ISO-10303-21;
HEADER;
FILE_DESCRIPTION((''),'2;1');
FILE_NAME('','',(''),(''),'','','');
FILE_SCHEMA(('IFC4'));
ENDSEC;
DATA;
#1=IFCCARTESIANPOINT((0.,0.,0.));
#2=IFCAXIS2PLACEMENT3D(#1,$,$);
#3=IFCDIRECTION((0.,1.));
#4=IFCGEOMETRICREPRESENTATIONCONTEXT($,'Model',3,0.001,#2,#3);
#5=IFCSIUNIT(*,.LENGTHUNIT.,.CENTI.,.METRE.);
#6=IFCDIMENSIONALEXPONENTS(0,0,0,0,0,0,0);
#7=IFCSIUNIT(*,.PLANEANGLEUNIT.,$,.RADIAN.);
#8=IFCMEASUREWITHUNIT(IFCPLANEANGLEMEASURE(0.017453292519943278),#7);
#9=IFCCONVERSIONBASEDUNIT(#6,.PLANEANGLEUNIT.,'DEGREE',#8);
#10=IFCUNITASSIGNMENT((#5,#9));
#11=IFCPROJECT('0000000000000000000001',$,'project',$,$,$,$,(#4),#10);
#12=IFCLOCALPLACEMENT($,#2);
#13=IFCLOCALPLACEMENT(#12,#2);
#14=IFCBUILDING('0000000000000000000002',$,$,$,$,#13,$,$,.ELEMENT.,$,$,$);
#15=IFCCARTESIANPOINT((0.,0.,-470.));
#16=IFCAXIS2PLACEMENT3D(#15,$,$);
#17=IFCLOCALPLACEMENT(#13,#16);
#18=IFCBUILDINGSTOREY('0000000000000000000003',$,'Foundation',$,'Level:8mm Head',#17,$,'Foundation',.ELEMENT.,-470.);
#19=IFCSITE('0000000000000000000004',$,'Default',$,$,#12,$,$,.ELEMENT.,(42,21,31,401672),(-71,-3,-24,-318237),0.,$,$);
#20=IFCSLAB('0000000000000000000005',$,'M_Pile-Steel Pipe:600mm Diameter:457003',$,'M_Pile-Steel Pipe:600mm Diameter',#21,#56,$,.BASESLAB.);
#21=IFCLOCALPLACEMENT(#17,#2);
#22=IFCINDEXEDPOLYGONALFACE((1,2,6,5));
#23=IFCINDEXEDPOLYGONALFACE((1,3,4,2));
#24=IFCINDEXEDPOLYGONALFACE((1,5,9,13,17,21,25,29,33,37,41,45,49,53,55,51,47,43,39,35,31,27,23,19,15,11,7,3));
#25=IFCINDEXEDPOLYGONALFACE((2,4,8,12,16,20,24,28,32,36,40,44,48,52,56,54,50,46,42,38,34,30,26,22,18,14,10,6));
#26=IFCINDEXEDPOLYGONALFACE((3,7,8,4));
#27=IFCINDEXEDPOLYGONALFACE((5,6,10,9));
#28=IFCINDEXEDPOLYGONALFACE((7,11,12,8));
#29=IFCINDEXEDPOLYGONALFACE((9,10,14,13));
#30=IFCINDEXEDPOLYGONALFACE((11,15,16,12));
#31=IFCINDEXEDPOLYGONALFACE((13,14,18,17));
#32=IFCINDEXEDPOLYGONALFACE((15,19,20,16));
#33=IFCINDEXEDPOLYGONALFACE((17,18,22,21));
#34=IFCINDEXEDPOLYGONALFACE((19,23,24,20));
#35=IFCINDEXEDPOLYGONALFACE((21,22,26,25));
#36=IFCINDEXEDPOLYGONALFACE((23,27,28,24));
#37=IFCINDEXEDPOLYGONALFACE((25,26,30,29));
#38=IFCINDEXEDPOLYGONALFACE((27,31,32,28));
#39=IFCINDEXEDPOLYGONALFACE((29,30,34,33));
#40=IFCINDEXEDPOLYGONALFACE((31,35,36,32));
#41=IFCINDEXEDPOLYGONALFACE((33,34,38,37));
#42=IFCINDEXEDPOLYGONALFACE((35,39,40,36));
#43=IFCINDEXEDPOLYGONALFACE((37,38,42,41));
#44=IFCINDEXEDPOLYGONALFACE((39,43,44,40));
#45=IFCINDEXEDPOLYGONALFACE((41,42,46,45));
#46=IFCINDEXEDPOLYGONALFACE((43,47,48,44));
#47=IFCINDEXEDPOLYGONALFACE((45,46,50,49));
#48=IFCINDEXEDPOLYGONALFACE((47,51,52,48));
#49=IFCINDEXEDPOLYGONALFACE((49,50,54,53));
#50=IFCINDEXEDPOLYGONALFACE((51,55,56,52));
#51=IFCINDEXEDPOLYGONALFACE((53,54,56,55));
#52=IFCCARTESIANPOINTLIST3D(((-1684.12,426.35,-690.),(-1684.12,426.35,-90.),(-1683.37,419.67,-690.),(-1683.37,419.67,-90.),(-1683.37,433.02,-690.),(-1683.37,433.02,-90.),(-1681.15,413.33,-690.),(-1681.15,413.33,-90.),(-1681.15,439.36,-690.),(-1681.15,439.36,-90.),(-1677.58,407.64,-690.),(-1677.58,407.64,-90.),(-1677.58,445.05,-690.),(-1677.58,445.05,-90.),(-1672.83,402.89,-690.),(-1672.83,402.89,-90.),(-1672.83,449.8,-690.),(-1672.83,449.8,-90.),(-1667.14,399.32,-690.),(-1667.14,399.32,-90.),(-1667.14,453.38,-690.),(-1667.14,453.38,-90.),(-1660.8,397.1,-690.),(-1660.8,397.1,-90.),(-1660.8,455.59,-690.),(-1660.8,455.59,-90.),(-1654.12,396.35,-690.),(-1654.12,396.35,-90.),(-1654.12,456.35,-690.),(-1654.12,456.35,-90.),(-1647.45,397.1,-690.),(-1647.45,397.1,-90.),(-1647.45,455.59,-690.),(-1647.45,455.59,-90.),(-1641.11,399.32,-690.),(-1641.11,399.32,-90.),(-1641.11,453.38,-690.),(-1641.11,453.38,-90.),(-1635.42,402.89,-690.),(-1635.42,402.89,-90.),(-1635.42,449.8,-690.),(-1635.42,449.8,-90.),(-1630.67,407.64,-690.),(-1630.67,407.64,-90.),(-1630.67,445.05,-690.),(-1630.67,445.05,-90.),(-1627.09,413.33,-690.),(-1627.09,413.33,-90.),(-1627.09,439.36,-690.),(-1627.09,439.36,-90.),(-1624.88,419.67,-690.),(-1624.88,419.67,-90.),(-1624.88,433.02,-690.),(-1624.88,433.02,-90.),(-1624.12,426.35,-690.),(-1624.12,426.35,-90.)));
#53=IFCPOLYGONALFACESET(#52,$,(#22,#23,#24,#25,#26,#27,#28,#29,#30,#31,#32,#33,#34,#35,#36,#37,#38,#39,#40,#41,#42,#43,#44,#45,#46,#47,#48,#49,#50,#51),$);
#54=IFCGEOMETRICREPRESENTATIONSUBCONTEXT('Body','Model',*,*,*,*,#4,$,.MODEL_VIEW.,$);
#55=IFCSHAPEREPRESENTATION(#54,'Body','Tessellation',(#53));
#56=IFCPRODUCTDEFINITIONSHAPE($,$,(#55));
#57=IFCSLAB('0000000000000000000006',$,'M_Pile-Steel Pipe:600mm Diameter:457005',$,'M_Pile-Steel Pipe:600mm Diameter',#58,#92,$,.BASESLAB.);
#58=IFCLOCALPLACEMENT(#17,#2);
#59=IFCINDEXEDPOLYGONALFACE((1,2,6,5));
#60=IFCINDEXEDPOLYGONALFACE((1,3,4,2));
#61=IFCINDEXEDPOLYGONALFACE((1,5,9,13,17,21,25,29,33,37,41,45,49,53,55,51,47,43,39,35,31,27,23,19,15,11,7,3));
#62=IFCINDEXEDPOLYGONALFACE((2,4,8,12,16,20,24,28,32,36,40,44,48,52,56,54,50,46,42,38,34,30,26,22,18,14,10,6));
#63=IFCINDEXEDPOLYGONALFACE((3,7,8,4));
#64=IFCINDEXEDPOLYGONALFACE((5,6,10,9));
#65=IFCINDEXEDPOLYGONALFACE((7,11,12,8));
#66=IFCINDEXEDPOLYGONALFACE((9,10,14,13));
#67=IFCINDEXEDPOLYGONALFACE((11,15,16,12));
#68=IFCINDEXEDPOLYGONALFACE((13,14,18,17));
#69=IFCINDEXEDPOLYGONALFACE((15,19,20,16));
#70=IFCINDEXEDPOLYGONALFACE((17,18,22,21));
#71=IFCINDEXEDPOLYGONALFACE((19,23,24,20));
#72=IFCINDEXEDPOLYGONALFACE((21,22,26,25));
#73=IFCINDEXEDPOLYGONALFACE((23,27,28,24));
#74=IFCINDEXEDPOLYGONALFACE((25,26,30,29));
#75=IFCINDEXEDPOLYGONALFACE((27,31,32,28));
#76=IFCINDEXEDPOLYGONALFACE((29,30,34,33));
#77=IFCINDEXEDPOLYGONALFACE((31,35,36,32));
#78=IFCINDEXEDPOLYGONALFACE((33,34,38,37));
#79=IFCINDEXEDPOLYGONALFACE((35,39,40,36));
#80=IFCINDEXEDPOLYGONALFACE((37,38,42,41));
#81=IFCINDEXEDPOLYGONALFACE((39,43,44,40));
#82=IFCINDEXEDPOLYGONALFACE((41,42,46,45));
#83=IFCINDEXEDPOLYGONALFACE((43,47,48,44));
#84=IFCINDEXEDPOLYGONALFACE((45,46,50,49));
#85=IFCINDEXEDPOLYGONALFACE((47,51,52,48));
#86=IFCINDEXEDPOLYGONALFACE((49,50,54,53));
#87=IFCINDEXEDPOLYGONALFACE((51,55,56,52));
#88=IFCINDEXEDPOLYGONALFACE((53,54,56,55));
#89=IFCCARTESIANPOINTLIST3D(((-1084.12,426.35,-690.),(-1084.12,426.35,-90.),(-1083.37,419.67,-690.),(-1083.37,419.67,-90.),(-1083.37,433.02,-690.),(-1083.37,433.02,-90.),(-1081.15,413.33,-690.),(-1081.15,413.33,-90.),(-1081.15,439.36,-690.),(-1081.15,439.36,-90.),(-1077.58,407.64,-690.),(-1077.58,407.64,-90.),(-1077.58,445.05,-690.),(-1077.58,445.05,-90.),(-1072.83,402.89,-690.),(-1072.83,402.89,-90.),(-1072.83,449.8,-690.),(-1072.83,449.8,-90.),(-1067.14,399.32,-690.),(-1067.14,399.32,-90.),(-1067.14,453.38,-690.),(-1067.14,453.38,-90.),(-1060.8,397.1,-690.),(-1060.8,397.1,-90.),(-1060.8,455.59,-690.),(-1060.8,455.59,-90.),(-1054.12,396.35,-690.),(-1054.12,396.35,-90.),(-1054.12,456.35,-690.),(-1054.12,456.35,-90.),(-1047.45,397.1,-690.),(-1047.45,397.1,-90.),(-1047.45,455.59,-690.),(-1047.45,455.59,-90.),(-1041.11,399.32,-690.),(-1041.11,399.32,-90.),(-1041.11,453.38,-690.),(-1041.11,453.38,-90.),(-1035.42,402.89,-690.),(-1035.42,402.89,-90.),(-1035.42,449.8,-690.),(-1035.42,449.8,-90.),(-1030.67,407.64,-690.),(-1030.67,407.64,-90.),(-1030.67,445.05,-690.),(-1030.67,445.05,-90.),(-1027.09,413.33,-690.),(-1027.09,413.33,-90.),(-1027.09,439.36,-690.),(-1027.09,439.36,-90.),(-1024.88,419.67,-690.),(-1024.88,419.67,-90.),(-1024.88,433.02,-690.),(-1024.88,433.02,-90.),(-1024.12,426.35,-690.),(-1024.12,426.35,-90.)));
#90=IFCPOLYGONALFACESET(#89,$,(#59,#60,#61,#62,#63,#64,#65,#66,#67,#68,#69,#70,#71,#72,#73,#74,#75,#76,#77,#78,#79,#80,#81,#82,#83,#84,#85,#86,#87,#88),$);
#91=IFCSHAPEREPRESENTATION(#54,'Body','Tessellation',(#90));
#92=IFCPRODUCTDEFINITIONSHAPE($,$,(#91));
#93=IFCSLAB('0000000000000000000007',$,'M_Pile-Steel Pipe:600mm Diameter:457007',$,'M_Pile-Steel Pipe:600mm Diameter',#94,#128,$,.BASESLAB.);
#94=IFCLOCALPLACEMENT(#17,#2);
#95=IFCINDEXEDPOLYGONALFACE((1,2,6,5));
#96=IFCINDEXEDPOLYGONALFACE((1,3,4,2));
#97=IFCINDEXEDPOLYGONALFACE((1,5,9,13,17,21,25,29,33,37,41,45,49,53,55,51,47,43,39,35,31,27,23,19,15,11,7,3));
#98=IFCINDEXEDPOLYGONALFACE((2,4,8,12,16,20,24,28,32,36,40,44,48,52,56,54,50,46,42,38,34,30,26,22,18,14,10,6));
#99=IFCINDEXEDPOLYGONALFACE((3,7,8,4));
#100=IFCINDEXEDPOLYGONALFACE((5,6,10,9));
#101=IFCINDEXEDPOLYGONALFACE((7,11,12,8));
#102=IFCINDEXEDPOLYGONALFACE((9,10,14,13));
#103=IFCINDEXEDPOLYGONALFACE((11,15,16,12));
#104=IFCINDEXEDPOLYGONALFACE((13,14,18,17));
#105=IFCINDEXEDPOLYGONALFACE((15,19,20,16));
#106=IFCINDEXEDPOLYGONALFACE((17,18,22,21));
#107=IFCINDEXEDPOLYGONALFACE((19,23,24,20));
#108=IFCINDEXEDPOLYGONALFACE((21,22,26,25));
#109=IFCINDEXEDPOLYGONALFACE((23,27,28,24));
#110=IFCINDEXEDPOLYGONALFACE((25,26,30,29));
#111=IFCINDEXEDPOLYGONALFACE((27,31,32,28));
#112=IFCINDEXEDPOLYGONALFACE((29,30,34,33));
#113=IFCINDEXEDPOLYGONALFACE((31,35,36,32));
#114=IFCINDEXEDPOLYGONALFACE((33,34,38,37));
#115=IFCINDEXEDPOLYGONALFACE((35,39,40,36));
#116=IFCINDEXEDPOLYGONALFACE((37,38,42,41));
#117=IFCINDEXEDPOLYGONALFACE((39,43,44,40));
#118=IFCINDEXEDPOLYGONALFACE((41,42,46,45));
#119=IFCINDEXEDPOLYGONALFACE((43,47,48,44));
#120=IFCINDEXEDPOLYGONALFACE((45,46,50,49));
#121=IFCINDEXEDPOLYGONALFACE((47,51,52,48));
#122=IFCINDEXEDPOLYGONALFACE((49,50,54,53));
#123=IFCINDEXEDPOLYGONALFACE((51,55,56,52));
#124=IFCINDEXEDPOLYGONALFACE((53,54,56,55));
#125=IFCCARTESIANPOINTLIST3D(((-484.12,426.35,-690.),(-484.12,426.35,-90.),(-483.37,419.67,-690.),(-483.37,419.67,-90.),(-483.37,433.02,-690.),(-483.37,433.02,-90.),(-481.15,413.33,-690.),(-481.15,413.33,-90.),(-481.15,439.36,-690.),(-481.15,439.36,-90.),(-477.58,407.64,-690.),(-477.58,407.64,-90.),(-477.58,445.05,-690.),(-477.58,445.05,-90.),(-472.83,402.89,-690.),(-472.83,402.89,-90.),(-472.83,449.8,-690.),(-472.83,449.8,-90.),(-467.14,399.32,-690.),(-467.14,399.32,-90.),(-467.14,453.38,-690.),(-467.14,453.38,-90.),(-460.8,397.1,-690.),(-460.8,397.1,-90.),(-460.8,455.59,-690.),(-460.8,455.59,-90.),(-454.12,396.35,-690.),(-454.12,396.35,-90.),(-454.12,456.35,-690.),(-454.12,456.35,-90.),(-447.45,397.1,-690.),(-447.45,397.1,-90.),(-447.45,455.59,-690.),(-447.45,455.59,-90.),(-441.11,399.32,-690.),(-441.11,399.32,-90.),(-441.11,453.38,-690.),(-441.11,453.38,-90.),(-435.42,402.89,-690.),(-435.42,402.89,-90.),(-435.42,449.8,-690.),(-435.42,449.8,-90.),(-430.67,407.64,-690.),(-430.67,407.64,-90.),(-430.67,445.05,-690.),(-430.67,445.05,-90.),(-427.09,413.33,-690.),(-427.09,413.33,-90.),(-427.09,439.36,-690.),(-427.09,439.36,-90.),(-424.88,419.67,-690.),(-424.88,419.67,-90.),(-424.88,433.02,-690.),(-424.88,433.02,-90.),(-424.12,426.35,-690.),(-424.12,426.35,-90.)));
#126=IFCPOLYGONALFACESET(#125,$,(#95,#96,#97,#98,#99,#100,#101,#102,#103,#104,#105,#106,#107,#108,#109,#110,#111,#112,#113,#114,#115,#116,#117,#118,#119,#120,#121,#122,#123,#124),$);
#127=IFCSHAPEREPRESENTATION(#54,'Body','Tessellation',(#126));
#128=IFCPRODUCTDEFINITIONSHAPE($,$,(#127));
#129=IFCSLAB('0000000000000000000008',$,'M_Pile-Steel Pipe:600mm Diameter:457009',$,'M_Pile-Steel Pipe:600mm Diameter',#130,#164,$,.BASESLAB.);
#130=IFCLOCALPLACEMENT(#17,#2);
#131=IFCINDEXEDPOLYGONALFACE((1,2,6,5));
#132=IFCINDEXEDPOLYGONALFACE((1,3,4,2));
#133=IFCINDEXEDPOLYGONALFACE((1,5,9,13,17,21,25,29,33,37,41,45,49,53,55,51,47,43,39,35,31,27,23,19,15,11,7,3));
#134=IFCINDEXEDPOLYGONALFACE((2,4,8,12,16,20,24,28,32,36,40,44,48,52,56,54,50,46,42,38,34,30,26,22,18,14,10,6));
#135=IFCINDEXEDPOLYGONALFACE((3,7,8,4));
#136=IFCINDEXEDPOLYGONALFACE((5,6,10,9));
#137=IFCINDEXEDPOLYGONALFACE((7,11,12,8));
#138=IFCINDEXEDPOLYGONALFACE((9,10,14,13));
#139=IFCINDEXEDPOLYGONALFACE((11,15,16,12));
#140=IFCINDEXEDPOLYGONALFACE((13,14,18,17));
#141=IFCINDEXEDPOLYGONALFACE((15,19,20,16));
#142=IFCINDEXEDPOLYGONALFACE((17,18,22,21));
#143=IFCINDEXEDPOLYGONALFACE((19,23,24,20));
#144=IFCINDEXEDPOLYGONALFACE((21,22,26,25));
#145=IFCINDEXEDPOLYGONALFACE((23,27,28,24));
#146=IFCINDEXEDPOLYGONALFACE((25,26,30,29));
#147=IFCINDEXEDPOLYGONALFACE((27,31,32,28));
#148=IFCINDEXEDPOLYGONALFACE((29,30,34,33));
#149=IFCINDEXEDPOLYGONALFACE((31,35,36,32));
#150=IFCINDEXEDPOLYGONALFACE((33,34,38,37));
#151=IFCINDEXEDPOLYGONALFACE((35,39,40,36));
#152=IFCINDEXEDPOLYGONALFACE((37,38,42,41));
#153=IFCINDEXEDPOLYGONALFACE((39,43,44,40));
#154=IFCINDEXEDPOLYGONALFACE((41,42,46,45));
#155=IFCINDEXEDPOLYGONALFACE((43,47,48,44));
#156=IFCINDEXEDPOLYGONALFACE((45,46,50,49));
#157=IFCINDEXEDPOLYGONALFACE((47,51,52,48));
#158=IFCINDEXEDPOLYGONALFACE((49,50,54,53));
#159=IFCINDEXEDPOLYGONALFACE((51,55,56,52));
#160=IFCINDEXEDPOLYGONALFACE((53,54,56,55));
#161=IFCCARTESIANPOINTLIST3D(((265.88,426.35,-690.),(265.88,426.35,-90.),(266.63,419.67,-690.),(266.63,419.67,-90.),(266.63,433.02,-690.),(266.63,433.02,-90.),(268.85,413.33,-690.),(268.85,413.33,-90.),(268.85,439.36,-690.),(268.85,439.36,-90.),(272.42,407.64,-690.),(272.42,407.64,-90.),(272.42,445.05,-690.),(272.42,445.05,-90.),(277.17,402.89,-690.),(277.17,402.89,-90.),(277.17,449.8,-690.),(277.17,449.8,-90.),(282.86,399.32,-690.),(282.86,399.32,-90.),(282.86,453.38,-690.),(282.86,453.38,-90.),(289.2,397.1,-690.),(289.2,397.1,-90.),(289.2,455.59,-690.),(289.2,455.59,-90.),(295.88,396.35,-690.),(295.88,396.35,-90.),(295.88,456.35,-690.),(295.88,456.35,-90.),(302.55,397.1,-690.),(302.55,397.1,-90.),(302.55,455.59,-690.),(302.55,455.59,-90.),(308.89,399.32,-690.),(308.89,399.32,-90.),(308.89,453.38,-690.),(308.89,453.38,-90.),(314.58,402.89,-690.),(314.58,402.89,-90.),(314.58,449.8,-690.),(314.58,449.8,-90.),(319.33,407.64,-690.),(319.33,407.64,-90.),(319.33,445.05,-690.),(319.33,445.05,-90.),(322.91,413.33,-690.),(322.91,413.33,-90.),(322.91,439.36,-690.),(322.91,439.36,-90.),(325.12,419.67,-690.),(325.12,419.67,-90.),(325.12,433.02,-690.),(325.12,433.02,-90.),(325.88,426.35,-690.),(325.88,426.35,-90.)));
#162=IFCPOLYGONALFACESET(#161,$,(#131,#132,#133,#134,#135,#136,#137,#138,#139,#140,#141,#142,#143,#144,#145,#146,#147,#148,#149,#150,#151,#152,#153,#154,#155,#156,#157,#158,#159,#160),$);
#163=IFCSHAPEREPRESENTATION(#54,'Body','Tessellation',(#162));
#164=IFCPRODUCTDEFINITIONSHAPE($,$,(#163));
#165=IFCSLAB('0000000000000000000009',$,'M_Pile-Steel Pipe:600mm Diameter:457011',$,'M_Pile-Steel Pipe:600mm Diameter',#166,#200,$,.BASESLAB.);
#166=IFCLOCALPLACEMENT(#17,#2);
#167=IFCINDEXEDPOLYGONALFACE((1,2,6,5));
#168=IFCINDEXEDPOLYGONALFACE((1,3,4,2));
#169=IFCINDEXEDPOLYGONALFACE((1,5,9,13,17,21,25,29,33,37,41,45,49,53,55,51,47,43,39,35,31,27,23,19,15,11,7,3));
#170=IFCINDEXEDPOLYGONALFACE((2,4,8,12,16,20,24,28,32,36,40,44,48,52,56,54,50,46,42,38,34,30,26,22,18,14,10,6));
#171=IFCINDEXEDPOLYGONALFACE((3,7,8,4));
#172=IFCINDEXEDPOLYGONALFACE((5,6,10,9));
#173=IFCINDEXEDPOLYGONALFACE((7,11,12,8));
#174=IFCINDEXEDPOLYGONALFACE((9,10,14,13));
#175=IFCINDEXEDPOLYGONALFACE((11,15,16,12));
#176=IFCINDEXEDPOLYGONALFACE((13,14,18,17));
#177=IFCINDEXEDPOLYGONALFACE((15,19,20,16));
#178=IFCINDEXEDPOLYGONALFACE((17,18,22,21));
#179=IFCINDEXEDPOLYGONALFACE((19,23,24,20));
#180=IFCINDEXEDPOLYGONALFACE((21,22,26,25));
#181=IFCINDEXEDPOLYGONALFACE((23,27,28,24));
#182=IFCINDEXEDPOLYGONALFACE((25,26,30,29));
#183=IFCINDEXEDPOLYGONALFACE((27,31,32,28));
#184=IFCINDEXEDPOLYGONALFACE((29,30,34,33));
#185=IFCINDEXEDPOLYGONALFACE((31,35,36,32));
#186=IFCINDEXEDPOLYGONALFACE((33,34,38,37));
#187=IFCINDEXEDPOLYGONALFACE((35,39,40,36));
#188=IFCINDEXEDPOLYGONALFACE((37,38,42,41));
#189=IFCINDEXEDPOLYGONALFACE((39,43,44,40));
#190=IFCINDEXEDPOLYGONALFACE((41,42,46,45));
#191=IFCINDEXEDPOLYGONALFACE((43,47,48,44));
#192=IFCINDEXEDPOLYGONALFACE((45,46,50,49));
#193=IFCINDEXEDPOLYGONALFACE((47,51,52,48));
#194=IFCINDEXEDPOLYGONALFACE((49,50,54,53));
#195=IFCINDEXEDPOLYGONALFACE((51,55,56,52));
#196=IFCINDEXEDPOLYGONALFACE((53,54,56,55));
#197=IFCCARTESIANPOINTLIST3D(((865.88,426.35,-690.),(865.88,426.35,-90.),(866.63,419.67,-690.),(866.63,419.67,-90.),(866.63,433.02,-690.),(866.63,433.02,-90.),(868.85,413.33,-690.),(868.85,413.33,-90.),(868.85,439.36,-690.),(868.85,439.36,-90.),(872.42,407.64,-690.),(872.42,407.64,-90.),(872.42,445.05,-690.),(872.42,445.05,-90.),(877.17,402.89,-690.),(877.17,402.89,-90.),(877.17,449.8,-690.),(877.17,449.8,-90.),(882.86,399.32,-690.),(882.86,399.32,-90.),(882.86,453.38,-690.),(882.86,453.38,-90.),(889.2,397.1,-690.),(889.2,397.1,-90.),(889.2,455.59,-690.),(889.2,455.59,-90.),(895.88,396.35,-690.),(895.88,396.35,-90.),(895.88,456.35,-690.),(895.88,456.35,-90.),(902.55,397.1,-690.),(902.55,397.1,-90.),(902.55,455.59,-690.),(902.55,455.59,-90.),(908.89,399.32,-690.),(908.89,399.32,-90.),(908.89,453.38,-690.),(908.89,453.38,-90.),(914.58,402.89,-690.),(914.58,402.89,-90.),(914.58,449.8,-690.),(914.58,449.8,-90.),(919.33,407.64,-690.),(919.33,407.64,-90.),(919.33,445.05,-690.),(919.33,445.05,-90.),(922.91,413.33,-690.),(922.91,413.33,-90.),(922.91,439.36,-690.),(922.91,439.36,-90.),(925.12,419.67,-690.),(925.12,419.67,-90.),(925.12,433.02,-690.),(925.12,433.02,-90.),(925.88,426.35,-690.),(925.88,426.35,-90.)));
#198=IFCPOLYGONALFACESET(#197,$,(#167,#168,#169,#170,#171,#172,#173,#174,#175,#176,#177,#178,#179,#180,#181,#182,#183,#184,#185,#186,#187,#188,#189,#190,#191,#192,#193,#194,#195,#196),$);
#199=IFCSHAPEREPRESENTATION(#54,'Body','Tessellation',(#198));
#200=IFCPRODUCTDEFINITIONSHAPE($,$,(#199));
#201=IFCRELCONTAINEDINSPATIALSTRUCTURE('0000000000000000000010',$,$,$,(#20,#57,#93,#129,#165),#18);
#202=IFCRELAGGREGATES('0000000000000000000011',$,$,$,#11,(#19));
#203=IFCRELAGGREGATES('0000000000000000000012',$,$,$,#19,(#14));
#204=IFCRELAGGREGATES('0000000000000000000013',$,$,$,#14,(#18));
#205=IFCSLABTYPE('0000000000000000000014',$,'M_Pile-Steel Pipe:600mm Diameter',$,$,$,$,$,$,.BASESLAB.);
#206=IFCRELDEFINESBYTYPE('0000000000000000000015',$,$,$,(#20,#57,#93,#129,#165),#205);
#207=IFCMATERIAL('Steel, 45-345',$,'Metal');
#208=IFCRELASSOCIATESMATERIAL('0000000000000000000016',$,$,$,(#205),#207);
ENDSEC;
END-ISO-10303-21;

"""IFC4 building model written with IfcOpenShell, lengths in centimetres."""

from ifc_helpers import new_model, entity, si_unit, converted_unit, direction, frame, origin, place, context, subcontext, project, spatial, arc, indexed_curve, outline, extrude, material, type_object, element, save


model = new_model("IFC4")

# Units and contexts
model_context = context("Model", 3, precision=0.001, world=origin(), true_north=direction((0.0, 1.0)))
body_context = subcontext(model_context, "Body", "Model", "MODEL_VIEW")
ifc_project = project(units=[si_unit("LENGTHUNIT", "METRE", prefix="CENTI"), converted_unit("PLANEANGLEUNIT", "DEGREE", entity("IfcPlaneAngleMeasure", 0.017453292519943278), si_unit("PLANEANGLEUNIT", "RADIAN"), dimensions=[0, 0, 0, 0, 0, 0, 0])], contexts=[model_context])

# Site, building, storey
site_placement = place(None, origin())
site = spatial("IfcSite", under=ifc_project, at=site_placement, Name="Default", CompositionType="ELEMENT", RefLatitude=(42, 21, 31, 401672), RefLongitude=(-71, -3, -24, -318237), RefElevation=0.0)
building_placement = place(site_placement, origin())
building = spatial("IfcBuilding", under=site, at=building_placement, CompositionType="ELEMENT")
storey_placement = place(building_placement, frame((0.0, 0.0, -470.0)))
storey = spatial("IfcBuildingStorey", under=building, at=storey_placement, Name="Foundation", ObjectType="Level:8mm Head", LongName="Foundation", CompositionType="ELEMENT", Elevation=-470.0)

# Slabs
ifc_material_1 = material(Name="Steel, 45-345", Category="Metal")
slab_type_1 = type_object("IfcSlabType", Name="M_Pile-Steel Pipe:600mm Diameter", PredefinedType="BASESLAB", material=ifc_material_1)
slab_1_placement = place(storey_placement, origin())
element("IfcSlab", 1, at=slab_1_placement, inside=storey, type_object=slab_type_1, Name="M_Pile-Steel Pipe:600mm Diameter:457003", ObjectType="M_Pile-Steel Pipe:600mm Diameter", PredefinedType="BASESLAB", context=body_context, shape_type="SweptSolid", body=[
    extrude(outline(indexed_curve([(-30.0, 0.0), (0.0, -30.0), (30.0, 0.0), (0.0, 30.0)], segments=[arc(1, 2, 3), arc(3, 4, 1)], self_intersect=False)), frame((-1654.12, 426.35, -690.0)), (0.0, 0.0, 1.0), 600.0),
])
slab_2_placement = place(storey_placement, origin())
element("IfcSlab", 2, at=slab_2_placement, inside=storey, type_object=slab_type_1, Name="M_Pile-Steel Pipe:600mm Diameter:457005", ObjectType="M_Pile-Steel Pipe:600mm Diameter", PredefinedType="BASESLAB", context=body_context, shape_type="SweptSolid", body=[
    extrude(outline(indexed_curve([(-30.0, 0.0), (0.0, -30.0), (30.0, 0.0), (0.0, 30.0)], segments=[arc(1, 2, 3), arc(3, 4, 1)], self_intersect=False)), frame((-1054.12, 426.35, -690.0)), (0.0, 0.0, 1.0), 600.0),
])
slab_3_placement = place(storey_placement, origin())
element("IfcSlab", 3, at=slab_3_placement, inside=storey, type_object=slab_type_1, Name="M_Pile-Steel Pipe:600mm Diameter:457007", ObjectType="M_Pile-Steel Pipe:600mm Diameter", PredefinedType="BASESLAB", context=body_context, shape_type="SweptSolid", body=[
    extrude(outline(indexed_curve([(-30.0, 0.0), (0.0, -30.0), (30.0, 0.0), (0.0, 30.0)], segments=[arc(1, 2, 3), arc(3, 4, 1)], self_intersect=False)), frame((-454.12, 426.35, -690.0)), (0.0, 0.0, 1.0), 600.0),
])
slab_4_placement = place(storey_placement, origin())
element("IfcSlab", 4, at=slab_4_placement, inside=storey, type_object=slab_type_1, Name="M_Pile-Steel Pipe:600mm Diameter:457009", ObjectType="M_Pile-Steel Pipe:600mm Diameter", PredefinedType="BASESLAB", context=body_context, shape_type="SweptSolid", body=[
    extrude(outline(indexed_curve([(-30.0, 0.0), (0.0, -30.0), (30.0, 0.0), (0.0, 30.0)], segments=[arc(1, 2, 3), arc(3, 4, 1)], self_intersect=False)), frame((295.88, 426.35, -690.0)), (0.0, 0.0, 1.0), 600.0),
])
slab_5_placement = place(storey_placement, origin())
element("IfcSlab", 5, at=slab_5_placement, inside=storey, type_object=slab_type_1, Name="M_Pile-Steel Pipe:600mm Diameter:457011", ObjectType="M_Pile-Steel Pipe:600mm Diameter", PredefinedType="BASESLAB", context=body_context, shape_type="SweptSolid", body=[
    extrude(outline(indexed_curve([(-30.0, 0.0), (0.0, -30.0), (30.0, 0.0), (0.0, 30.0)], segments=[arc(1, 2, 3), arc(3, 4, 1)], self_intersect=False)), frame((895.88, 426.35, -690.0)), (0.0, 0.0, 1.0), 600.0),
])

save(model, "model.ifc")
